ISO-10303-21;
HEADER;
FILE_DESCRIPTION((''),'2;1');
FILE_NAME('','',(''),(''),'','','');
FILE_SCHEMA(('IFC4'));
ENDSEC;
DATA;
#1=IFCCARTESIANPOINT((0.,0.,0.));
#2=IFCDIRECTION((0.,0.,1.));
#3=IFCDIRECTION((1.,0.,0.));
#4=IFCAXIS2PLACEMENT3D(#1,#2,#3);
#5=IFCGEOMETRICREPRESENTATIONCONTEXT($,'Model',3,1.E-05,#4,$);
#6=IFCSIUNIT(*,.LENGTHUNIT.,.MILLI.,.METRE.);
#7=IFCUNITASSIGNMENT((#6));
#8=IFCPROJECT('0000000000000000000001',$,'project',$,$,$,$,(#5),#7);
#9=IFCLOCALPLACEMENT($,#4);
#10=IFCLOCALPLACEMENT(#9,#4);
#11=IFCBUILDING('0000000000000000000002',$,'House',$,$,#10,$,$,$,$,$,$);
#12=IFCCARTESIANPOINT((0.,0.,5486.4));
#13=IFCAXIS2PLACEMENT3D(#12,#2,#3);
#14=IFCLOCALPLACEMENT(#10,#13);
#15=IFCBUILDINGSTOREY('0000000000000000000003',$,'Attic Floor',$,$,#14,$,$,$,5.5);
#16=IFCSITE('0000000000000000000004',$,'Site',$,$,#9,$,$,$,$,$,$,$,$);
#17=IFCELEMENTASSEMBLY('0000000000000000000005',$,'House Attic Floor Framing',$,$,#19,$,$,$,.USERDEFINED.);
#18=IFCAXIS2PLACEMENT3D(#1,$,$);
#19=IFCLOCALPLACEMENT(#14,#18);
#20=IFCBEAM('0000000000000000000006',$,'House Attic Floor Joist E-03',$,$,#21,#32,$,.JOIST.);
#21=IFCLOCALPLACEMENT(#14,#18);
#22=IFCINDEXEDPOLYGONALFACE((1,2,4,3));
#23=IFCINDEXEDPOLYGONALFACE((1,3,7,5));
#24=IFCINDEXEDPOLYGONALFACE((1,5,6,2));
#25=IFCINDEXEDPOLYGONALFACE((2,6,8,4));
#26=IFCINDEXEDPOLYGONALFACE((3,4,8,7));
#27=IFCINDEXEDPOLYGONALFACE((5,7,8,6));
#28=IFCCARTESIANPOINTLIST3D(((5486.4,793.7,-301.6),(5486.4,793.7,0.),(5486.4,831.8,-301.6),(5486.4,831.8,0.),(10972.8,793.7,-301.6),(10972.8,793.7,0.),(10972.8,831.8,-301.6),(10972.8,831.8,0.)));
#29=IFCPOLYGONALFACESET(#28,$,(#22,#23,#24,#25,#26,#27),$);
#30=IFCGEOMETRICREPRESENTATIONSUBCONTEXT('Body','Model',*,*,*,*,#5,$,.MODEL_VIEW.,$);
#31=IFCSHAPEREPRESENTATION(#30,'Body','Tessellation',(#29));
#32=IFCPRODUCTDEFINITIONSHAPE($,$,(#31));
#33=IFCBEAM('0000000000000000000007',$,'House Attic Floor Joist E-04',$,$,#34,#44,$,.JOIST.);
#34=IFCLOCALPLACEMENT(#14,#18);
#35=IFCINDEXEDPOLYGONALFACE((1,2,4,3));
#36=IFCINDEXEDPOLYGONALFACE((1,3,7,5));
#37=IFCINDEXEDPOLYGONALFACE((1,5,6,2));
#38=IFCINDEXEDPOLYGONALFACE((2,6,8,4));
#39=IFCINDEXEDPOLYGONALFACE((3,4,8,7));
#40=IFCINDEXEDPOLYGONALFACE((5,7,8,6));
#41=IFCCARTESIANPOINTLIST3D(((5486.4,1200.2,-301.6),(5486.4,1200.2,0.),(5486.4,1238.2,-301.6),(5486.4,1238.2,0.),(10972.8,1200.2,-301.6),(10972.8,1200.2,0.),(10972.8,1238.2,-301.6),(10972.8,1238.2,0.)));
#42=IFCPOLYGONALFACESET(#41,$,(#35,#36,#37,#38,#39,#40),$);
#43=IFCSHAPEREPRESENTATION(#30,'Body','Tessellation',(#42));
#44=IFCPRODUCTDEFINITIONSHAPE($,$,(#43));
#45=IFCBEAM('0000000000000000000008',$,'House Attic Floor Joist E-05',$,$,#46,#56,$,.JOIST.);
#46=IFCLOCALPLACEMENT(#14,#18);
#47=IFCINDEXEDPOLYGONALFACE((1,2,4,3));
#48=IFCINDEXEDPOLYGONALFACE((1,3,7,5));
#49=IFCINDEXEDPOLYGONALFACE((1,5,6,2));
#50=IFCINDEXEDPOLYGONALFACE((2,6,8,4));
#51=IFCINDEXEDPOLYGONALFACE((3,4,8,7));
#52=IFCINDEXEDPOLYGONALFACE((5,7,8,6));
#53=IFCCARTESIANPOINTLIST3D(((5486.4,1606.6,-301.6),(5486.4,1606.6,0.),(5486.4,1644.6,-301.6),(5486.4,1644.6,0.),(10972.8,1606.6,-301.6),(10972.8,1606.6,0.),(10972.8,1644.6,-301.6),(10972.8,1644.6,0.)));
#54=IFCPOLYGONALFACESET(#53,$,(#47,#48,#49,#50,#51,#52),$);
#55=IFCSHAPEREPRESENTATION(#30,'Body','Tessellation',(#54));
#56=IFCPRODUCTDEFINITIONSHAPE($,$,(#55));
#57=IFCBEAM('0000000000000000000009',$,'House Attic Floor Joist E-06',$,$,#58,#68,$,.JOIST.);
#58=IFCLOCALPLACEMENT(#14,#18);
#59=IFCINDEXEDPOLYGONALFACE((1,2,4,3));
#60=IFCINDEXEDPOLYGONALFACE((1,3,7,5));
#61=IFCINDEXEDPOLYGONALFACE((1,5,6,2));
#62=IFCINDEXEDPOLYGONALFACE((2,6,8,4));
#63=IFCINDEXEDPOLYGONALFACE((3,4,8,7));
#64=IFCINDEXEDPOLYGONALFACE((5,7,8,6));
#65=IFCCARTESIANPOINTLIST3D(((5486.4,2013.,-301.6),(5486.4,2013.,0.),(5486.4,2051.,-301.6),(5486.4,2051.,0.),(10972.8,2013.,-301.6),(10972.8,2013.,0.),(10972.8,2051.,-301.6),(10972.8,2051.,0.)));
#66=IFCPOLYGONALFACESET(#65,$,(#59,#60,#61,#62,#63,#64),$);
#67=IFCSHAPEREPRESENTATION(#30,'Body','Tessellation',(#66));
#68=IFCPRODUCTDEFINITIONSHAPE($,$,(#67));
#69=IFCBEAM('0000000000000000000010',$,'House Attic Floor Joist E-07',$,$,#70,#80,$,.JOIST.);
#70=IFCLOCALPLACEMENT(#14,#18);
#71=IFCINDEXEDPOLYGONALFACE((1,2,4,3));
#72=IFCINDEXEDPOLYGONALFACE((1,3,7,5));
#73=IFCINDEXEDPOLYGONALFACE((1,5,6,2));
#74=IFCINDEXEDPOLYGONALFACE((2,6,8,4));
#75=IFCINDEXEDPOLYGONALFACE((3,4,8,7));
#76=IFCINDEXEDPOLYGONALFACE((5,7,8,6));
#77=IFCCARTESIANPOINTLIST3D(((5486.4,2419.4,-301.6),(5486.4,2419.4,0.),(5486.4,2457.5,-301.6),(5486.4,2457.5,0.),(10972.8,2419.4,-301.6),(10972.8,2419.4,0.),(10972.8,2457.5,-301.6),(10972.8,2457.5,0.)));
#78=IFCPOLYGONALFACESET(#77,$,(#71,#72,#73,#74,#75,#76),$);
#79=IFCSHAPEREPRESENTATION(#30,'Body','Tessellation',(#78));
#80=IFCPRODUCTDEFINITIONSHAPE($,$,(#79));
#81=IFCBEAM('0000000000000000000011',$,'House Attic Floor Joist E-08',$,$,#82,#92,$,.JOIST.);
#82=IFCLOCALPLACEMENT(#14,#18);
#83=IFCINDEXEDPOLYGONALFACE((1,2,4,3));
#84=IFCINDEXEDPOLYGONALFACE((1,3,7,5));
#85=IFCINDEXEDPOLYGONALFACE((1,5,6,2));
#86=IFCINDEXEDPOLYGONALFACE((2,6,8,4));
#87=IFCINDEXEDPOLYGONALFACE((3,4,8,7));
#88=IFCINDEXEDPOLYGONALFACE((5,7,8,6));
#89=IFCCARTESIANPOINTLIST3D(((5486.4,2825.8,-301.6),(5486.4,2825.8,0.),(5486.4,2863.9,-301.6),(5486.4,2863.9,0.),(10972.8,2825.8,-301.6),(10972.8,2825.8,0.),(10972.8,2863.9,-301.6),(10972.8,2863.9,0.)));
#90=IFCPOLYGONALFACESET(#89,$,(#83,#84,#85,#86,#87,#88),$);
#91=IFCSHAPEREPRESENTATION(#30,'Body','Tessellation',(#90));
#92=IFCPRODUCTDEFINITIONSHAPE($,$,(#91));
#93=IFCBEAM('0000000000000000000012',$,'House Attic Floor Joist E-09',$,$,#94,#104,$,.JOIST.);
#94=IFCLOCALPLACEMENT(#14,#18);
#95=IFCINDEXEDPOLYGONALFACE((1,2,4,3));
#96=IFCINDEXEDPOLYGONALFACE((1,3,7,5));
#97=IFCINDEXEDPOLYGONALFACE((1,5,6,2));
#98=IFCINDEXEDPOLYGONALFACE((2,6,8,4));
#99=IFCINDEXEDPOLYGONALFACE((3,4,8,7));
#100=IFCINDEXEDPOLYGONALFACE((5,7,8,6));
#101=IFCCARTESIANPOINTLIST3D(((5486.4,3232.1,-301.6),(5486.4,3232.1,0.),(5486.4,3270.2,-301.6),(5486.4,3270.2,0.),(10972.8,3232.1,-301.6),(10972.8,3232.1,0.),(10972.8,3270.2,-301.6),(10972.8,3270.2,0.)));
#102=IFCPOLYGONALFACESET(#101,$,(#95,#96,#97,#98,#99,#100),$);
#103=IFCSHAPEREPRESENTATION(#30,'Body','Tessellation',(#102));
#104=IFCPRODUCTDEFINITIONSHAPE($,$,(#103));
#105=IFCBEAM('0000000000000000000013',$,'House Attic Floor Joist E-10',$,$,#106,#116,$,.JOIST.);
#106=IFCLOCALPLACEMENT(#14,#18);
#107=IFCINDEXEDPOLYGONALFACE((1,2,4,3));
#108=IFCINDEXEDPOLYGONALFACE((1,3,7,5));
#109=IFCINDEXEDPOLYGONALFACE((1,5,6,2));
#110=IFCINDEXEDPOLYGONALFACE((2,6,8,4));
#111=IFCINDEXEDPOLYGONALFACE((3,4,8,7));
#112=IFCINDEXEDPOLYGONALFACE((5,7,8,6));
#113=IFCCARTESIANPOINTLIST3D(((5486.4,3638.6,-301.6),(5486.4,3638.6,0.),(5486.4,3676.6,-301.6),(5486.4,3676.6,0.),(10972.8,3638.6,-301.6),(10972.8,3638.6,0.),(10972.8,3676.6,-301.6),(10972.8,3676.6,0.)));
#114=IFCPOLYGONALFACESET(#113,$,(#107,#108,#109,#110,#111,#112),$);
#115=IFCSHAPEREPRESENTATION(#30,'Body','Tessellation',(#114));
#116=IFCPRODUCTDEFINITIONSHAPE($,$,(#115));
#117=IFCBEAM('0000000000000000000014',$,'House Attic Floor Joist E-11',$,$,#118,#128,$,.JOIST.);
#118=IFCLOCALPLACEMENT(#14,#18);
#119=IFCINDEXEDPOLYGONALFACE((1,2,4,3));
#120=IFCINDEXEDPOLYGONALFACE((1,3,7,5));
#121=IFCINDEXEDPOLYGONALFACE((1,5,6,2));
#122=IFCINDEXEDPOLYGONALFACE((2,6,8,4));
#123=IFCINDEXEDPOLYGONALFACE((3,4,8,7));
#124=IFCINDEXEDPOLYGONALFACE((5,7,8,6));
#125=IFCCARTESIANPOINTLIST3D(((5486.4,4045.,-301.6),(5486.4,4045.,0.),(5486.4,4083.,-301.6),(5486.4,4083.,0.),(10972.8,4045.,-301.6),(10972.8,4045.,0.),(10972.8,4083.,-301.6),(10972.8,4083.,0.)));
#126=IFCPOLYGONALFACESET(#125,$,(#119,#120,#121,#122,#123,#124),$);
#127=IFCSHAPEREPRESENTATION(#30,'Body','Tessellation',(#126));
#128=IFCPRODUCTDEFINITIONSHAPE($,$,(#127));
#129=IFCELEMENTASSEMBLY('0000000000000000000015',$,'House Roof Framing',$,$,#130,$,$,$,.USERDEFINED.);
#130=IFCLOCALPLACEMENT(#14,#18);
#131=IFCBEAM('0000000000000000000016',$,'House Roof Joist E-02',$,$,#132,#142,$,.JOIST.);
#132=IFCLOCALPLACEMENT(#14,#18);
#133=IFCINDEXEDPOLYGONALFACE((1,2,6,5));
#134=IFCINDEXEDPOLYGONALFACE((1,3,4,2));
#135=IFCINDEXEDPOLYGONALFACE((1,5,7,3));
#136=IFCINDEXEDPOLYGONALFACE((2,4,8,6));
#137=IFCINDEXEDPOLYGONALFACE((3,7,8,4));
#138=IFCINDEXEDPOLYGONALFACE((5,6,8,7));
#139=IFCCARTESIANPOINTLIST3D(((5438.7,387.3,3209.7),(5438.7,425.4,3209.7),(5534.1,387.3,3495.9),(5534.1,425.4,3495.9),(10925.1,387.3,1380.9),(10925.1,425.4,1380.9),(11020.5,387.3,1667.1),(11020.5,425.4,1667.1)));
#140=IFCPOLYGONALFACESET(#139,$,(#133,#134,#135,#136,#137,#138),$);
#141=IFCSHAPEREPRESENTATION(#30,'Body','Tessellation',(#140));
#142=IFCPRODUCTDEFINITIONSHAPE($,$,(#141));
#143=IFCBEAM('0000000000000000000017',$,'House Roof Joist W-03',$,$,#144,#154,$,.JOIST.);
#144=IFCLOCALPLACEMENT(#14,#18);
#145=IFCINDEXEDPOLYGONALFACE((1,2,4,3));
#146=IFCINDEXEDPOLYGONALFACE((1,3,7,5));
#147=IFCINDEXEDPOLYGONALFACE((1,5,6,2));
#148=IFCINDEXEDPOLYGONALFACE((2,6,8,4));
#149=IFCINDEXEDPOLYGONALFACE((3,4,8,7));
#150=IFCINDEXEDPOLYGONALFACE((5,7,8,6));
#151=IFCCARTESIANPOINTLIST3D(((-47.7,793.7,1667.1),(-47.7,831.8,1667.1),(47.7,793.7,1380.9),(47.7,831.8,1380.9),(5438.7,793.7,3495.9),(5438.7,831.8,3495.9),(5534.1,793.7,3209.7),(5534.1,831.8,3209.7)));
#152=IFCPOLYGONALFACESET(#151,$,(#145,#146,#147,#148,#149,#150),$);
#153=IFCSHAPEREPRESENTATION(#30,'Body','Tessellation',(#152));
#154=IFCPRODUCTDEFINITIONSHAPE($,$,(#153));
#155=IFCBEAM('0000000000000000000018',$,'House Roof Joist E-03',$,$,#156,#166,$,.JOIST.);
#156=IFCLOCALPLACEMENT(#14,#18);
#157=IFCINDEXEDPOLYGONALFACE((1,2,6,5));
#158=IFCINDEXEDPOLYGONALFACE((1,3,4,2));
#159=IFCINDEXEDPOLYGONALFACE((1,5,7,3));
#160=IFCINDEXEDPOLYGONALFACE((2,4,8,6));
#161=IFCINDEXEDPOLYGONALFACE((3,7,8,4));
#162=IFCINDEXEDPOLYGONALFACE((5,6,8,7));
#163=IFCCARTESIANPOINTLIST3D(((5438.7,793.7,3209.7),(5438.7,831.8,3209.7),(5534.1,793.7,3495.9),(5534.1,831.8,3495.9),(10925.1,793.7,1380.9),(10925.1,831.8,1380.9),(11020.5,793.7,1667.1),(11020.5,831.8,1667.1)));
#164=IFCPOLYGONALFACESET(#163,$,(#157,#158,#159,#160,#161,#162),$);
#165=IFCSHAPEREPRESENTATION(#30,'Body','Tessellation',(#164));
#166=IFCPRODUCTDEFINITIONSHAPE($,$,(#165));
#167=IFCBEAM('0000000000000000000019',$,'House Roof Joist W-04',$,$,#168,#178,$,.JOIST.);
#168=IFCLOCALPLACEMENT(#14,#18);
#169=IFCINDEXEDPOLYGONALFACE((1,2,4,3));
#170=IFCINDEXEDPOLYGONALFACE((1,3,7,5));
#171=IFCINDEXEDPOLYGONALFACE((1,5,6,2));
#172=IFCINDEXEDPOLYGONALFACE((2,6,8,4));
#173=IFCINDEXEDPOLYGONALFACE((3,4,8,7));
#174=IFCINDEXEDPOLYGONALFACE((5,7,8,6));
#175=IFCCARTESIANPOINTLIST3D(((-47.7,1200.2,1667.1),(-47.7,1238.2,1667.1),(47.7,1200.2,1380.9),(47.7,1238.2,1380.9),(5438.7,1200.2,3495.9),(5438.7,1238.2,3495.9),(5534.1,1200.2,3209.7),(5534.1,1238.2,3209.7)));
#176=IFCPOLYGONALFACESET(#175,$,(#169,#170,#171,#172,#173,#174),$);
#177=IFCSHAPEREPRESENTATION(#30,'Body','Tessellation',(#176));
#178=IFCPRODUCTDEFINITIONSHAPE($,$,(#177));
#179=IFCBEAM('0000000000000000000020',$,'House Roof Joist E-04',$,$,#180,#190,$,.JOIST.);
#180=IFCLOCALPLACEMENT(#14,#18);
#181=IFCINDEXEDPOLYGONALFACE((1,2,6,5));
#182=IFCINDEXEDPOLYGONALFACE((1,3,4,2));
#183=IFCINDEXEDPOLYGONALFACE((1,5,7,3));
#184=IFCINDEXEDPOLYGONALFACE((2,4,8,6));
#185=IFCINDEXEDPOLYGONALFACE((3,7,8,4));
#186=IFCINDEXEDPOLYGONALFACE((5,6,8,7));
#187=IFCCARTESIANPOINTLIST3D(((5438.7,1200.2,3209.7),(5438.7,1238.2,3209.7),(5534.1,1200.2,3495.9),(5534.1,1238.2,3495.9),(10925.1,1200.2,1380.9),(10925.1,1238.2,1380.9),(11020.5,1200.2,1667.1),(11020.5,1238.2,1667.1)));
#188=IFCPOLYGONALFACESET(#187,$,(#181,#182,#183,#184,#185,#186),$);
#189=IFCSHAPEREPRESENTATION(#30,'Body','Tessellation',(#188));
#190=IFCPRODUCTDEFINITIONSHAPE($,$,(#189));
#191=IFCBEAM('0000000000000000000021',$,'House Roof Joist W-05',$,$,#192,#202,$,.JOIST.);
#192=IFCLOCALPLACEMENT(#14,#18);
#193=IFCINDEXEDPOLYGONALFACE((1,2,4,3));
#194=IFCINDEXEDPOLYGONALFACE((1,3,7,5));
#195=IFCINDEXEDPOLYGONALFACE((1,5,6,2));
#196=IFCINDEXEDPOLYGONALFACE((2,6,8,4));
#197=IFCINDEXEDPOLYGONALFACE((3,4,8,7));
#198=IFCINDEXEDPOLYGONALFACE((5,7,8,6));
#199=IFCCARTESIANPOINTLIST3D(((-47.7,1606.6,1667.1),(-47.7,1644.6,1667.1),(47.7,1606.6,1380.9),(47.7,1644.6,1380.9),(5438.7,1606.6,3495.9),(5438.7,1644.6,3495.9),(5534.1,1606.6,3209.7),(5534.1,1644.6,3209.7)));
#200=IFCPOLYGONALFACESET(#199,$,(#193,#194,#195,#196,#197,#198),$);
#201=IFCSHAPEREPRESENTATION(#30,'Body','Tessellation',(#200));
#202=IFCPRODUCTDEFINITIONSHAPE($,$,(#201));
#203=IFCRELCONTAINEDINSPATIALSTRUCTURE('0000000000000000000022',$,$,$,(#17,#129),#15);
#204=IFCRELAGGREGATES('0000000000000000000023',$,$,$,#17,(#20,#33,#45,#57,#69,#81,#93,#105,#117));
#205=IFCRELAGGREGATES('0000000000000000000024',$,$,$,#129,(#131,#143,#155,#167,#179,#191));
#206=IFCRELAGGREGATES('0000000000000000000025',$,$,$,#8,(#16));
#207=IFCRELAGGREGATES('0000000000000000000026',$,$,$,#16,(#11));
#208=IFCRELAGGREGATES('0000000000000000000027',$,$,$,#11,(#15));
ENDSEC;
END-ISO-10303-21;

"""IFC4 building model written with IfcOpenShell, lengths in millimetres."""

from ifc_helpers import new_model, si_unit, frame, origin_with_axes, origin_2d, place, context, subcontext, project, spatial, rectangle, extrude, element, aggregate, save


model = new_model("IFC4")

# Units and contexts
model_context = context("Model", 3, precision=1e-05, world=origin_with_axes())
body_context = subcontext(model_context, "Body", "Model", "MODEL_VIEW")
ifc_project = project(units=[si_unit("LENGTHUNIT", "METRE", prefix="MILLI")], contexts=[model_context])

# Site, building, storey
site_placement = place(None, origin_with_axes())
site = spatial("IfcSite", under=ifc_project, at=site_placement, Name="Site")
building_placement = place(site_placement, origin_with_axes())
building = spatial("IfcBuilding", under=site, at=building_placement, Name="House")
storey_placement = place(building_placement, frame((0.0, 0.0, 5486.4), z_axis=(0.0, 0.0, 1.0), x_axis=(1.0, 0.0, 0.0)))
storey = spatial("IfcBuildingStorey", under=building, at=storey_placement, Name="Attic Floor", Elevation=5.5)

# Element assemblies, beams
assembly_1_placement = place(storey_placement, frame((0.0, 0.0, -5486.4), z_axis=(0.0, 0.0, 1.0), x_axis=(1.0, 0.0, 0.0)))
assembly_1 = element("IfcElementAssembly", 1, at=assembly_1_placement, inside=storey, Name="House Attic Floor Framing", PredefinedType="USERDEFINED")
beam_1_placement = place(assembly_1_placement, frame((5486.4, 812.8, 5335.6), z_axis=(1.0, 0.0, 0.0), x_axis=(0.0, 1.0, 0.0)))
beam_1 = element("IfcBeam", 2, at=beam_1_placement, Name="House Attic Floor Joist E-03", PredefinedType="JOIST", context=body_context, shape_type="SweptSolid", body=[
    extrude(rectangle(XDim=38.1, YDim=301.6, at=origin_2d()), origin_with_axes(), (0.0, 0.0, 1.0), 5486.4),
])
beam_2_placement = place(assembly_1_placement, frame((5486.4, 1219.2, 5335.6), z_axis=(1.0, 0.0, 0.0), x_axis=(0.0, 1.0, 0.0)))
beam_2 = element("IfcBeam", 3, at=beam_2_placement, Name="House Attic Floor Joist E-04", PredefinedType="JOIST", context=body_context, shape_type="SweptSolid", body=[
    extrude(rectangle(XDim=38.1, YDim=301.6, at=origin_2d()), origin_with_axes(), (0.0, 0.0, 1.0), 5486.4),
])
beam_3_placement = place(assembly_1_placement, frame((5486.4, 1625.6, 5335.6), z_axis=(1.0, 0.0, 0.0), x_axis=(0.0, 1.0, 0.0)))
beam_3 = element("IfcBeam", 4, at=beam_3_placement, Name="House Attic Floor Joist E-05", PredefinedType="JOIST", context=body_context, shape_type="SweptSolid", body=[
    extrude(rectangle(XDim=38.1, YDim=301.6, at=origin_2d()), origin_with_axes(), (0.0, 0.0, 1.0), 5486.4),
])
beam_4_placement = place(assembly_1_placement, frame((5486.4, 2032.0, 5335.6), z_axis=(1.0, 0.0, 0.0), x_axis=(0.0, 1.0, 0.0)))
beam_4 = element("IfcBeam", 5, at=beam_4_placement, Name="House Attic Floor Joist E-06", PredefinedType="JOIST", context=body_context, shape_type="SweptSolid", body=[
    extrude(rectangle(XDim=38.1, YDim=301.6, at=origin_2d()), origin_with_axes(), (0.0, 0.0, 1.0), 5486.4),
])
beam_5_placement = place(assembly_1_placement, frame((5486.4, 2438.4, 5335.6), z_axis=(1.0, 0.0, 0.0), x_axis=(0.0, 1.0, 0.0)))
beam_5 = element("IfcBeam", 6, at=beam_5_placement, Name="House Attic Floor Joist E-07", PredefinedType="JOIST", context=body_context, shape_type="SweptSolid", body=[
    extrude(rectangle(XDim=38.1, YDim=301.6, at=origin_2d()), origin_with_axes(), (0.0, 0.0, 1.0), 5486.4),
])
beam_6_placement = place(assembly_1_placement, frame((5486.4, 2844.8, 5335.6), z_axis=(1.0, 0.0, 0.0), x_axis=(0.0, 1.0, 0.0)))
beam_6 = element("IfcBeam", 7, at=beam_6_placement, Name="House Attic Floor Joist E-08", PredefinedType="JOIST", context=body_context, shape_type="SweptSolid", body=[
    extrude(rectangle(XDim=38.1, YDim=301.6, at=origin_2d()), origin_with_axes(), (0.0, 0.0, 1.0), 5486.4),
])
beam_7_placement = place(assembly_1_placement, frame((5486.4, 3251.2, 5335.6), z_axis=(1.0, 0.0, 0.0), x_axis=(0.0, 1.0, 0.0)))
beam_7 = element("IfcBeam", 8, at=beam_7_placement, Name="House Attic Floor Joist E-09", PredefinedType="JOIST", context=body_context, shape_type="SweptSolid", body=[
    extrude(rectangle(XDim=38.1, YDim=301.6, at=origin_2d()), origin_with_axes(), (0.0, 0.0, 1.0), 5486.4),
])
beam_8_placement = place(assembly_1_placement, frame((5486.4, 3657.6, 5335.6), z_axis=(1.0, 0.0, 0.0), x_axis=(0.0, 1.0, 0.0)))
beam_8 = element("IfcBeam", 9, at=beam_8_placement, Name="House Attic Floor Joist E-10", PredefinedType="JOIST", context=body_context, shape_type="SweptSolid", body=[
    extrude(rectangle(XDim=38.1, YDim=301.6, at=origin_2d()), origin_with_axes(), (0.0, 0.0, 1.0), 5486.4),
])
beam_9_placement = place(assembly_1_placement, frame((5486.4, 4064.0, 5335.6), z_axis=(1.0, 0.0, 0.0), x_axis=(0.0, 1.0, 0.0)))
beam_9 = element("IfcBeam", 10, at=beam_9_placement, Name="House Attic Floor Joist E-11", PredefinedType="JOIST", context=body_context, shape_type="SweptSolid", body=[
    extrude(rectangle(XDim=38.1, YDim=301.6, at=origin_2d()), origin_with_axes(), (0.0, 0.0, 1.0), 5486.4),
])
aggregate(assembly_1, [beam_1, beam_2, beam_3, beam_4, beam_5, beam_6, beam_7, beam_8, beam_9])
assembly_2_placement = place(storey_placement, frame((0.0, 0.0, -5486.4), z_axis=(0.0, 0.0, 1.0), x_axis=(1.0, 0.0, 0.0)))
assembly_2 = element("IfcElementAssembly", 11, at=assembly_2_placement, inside=storey, Name="House Roof Framing", PredefinedType="USERDEFINED")
beam_10_placement = place(assembly_2_placement, frame((5486.4, 406.4, 8839.2), z_axis=(0.948683, 0.0, -0.316228), x_axis=(0.0, 1.0, 0.0)))
beam_10 = element("IfcBeam", 12, at=beam_10_placement, Name="House Roof Joist E-02", PredefinedType="JOIST", context=body_context, shape_type="SweptSolid", body=[
    extrude(rectangle(XDim=38.1, YDim=301.6, at=origin_2d()), origin_with_axes(), (0.0, 0.0, 1.0), 5783.2),
])
beam_11_placement = place(assembly_2_placement, frame((5486.4, 812.8, 8839.2), z_axis=(-0.948683, 0.0, -0.316228), x_axis=(0.0, 1.0, 0.0)))
beam_11 = element("IfcBeam", 13, at=beam_11_placement, Name="House Roof Joist W-03", PredefinedType="JOIST", context=body_context, shape_type="SweptSolid", body=[
    extrude(rectangle(XDim=38.1, YDim=301.6, at=origin_2d()), origin_with_axes(), (0.0, 0.0, 1.0), 5783.2),
])
beam_12_placement = place(assembly_2_placement, frame((5486.4, 812.8, 8839.2), z_axis=(0.948683, 0.0, -0.316228), x_axis=(0.0, 1.0, 0.0)))
beam_12 = element("IfcBeam", 14, at=beam_12_placement, Name="House Roof Joist E-03", PredefinedType="JOIST", context=body_context, shape_type="SweptSolid", body=[
    extrude(rectangle(XDim=38.1, YDim=301.6, at=origin_2d()), origin_with_axes(), (0.0, 0.0, 1.0), 5783.2),
])
beam_13_placement = place(assembly_2_placement, frame((5486.4, 1219.2, 8839.2), z_axis=(-0.948683, 0.0, -0.316228), x_axis=(0.0, 1.0, 0.0)))
beam_13 = element("IfcBeam", 15, at=beam_13_placement, Name="House Roof Joist W-04", PredefinedType="JOIST", context=body_context, shape_type="SweptSolid", body=[
    extrude(rectangle(XDim=38.1, YDim=301.6, at=origin_2d()), origin_with_axes(), (0.0, 0.0, 1.0), 5783.2),
])
beam_14_placement = place(assembly_2_placement, frame((5486.4, 1219.2, 8839.2), z_axis=(0.948683, 0.0, -0.316228), x_axis=(0.0, 1.0, 0.0)))
beam_14 = element("IfcBeam", 16, at=beam_14_placement, Name="House Roof Joist E-04", PredefinedType="JOIST", context=body_context, shape_type="SweptSolid", body=[
    extrude(rectangle(XDim=38.1, YDim=301.6, at=origin_2d()), origin_with_axes(), (0.0, 0.0, 1.0), 5783.2),
])
beam_15_placement = place(assembly_2_placement, frame((5486.4, 1625.6, 8839.2), z_axis=(-0.948683, 0.0, -0.316228), x_axis=(0.0, 1.0, 0.0)))
beam_15 = element("IfcBeam", 17, at=beam_15_placement, Name="House Roof Joist W-05", PredefinedType="JOIST", context=body_context, shape_type="SweptSolid", body=[
    extrude(rectangle(XDim=38.1, YDim=301.6, at=origin_2d()), origin_with_axes(), (0.0, 0.0, 1.0), 5783.2),
])
aggregate(assembly_2, [beam_10, beam_11, beam_12, beam_13, beam_14, beam_15])

save(model, "model.ifc")
